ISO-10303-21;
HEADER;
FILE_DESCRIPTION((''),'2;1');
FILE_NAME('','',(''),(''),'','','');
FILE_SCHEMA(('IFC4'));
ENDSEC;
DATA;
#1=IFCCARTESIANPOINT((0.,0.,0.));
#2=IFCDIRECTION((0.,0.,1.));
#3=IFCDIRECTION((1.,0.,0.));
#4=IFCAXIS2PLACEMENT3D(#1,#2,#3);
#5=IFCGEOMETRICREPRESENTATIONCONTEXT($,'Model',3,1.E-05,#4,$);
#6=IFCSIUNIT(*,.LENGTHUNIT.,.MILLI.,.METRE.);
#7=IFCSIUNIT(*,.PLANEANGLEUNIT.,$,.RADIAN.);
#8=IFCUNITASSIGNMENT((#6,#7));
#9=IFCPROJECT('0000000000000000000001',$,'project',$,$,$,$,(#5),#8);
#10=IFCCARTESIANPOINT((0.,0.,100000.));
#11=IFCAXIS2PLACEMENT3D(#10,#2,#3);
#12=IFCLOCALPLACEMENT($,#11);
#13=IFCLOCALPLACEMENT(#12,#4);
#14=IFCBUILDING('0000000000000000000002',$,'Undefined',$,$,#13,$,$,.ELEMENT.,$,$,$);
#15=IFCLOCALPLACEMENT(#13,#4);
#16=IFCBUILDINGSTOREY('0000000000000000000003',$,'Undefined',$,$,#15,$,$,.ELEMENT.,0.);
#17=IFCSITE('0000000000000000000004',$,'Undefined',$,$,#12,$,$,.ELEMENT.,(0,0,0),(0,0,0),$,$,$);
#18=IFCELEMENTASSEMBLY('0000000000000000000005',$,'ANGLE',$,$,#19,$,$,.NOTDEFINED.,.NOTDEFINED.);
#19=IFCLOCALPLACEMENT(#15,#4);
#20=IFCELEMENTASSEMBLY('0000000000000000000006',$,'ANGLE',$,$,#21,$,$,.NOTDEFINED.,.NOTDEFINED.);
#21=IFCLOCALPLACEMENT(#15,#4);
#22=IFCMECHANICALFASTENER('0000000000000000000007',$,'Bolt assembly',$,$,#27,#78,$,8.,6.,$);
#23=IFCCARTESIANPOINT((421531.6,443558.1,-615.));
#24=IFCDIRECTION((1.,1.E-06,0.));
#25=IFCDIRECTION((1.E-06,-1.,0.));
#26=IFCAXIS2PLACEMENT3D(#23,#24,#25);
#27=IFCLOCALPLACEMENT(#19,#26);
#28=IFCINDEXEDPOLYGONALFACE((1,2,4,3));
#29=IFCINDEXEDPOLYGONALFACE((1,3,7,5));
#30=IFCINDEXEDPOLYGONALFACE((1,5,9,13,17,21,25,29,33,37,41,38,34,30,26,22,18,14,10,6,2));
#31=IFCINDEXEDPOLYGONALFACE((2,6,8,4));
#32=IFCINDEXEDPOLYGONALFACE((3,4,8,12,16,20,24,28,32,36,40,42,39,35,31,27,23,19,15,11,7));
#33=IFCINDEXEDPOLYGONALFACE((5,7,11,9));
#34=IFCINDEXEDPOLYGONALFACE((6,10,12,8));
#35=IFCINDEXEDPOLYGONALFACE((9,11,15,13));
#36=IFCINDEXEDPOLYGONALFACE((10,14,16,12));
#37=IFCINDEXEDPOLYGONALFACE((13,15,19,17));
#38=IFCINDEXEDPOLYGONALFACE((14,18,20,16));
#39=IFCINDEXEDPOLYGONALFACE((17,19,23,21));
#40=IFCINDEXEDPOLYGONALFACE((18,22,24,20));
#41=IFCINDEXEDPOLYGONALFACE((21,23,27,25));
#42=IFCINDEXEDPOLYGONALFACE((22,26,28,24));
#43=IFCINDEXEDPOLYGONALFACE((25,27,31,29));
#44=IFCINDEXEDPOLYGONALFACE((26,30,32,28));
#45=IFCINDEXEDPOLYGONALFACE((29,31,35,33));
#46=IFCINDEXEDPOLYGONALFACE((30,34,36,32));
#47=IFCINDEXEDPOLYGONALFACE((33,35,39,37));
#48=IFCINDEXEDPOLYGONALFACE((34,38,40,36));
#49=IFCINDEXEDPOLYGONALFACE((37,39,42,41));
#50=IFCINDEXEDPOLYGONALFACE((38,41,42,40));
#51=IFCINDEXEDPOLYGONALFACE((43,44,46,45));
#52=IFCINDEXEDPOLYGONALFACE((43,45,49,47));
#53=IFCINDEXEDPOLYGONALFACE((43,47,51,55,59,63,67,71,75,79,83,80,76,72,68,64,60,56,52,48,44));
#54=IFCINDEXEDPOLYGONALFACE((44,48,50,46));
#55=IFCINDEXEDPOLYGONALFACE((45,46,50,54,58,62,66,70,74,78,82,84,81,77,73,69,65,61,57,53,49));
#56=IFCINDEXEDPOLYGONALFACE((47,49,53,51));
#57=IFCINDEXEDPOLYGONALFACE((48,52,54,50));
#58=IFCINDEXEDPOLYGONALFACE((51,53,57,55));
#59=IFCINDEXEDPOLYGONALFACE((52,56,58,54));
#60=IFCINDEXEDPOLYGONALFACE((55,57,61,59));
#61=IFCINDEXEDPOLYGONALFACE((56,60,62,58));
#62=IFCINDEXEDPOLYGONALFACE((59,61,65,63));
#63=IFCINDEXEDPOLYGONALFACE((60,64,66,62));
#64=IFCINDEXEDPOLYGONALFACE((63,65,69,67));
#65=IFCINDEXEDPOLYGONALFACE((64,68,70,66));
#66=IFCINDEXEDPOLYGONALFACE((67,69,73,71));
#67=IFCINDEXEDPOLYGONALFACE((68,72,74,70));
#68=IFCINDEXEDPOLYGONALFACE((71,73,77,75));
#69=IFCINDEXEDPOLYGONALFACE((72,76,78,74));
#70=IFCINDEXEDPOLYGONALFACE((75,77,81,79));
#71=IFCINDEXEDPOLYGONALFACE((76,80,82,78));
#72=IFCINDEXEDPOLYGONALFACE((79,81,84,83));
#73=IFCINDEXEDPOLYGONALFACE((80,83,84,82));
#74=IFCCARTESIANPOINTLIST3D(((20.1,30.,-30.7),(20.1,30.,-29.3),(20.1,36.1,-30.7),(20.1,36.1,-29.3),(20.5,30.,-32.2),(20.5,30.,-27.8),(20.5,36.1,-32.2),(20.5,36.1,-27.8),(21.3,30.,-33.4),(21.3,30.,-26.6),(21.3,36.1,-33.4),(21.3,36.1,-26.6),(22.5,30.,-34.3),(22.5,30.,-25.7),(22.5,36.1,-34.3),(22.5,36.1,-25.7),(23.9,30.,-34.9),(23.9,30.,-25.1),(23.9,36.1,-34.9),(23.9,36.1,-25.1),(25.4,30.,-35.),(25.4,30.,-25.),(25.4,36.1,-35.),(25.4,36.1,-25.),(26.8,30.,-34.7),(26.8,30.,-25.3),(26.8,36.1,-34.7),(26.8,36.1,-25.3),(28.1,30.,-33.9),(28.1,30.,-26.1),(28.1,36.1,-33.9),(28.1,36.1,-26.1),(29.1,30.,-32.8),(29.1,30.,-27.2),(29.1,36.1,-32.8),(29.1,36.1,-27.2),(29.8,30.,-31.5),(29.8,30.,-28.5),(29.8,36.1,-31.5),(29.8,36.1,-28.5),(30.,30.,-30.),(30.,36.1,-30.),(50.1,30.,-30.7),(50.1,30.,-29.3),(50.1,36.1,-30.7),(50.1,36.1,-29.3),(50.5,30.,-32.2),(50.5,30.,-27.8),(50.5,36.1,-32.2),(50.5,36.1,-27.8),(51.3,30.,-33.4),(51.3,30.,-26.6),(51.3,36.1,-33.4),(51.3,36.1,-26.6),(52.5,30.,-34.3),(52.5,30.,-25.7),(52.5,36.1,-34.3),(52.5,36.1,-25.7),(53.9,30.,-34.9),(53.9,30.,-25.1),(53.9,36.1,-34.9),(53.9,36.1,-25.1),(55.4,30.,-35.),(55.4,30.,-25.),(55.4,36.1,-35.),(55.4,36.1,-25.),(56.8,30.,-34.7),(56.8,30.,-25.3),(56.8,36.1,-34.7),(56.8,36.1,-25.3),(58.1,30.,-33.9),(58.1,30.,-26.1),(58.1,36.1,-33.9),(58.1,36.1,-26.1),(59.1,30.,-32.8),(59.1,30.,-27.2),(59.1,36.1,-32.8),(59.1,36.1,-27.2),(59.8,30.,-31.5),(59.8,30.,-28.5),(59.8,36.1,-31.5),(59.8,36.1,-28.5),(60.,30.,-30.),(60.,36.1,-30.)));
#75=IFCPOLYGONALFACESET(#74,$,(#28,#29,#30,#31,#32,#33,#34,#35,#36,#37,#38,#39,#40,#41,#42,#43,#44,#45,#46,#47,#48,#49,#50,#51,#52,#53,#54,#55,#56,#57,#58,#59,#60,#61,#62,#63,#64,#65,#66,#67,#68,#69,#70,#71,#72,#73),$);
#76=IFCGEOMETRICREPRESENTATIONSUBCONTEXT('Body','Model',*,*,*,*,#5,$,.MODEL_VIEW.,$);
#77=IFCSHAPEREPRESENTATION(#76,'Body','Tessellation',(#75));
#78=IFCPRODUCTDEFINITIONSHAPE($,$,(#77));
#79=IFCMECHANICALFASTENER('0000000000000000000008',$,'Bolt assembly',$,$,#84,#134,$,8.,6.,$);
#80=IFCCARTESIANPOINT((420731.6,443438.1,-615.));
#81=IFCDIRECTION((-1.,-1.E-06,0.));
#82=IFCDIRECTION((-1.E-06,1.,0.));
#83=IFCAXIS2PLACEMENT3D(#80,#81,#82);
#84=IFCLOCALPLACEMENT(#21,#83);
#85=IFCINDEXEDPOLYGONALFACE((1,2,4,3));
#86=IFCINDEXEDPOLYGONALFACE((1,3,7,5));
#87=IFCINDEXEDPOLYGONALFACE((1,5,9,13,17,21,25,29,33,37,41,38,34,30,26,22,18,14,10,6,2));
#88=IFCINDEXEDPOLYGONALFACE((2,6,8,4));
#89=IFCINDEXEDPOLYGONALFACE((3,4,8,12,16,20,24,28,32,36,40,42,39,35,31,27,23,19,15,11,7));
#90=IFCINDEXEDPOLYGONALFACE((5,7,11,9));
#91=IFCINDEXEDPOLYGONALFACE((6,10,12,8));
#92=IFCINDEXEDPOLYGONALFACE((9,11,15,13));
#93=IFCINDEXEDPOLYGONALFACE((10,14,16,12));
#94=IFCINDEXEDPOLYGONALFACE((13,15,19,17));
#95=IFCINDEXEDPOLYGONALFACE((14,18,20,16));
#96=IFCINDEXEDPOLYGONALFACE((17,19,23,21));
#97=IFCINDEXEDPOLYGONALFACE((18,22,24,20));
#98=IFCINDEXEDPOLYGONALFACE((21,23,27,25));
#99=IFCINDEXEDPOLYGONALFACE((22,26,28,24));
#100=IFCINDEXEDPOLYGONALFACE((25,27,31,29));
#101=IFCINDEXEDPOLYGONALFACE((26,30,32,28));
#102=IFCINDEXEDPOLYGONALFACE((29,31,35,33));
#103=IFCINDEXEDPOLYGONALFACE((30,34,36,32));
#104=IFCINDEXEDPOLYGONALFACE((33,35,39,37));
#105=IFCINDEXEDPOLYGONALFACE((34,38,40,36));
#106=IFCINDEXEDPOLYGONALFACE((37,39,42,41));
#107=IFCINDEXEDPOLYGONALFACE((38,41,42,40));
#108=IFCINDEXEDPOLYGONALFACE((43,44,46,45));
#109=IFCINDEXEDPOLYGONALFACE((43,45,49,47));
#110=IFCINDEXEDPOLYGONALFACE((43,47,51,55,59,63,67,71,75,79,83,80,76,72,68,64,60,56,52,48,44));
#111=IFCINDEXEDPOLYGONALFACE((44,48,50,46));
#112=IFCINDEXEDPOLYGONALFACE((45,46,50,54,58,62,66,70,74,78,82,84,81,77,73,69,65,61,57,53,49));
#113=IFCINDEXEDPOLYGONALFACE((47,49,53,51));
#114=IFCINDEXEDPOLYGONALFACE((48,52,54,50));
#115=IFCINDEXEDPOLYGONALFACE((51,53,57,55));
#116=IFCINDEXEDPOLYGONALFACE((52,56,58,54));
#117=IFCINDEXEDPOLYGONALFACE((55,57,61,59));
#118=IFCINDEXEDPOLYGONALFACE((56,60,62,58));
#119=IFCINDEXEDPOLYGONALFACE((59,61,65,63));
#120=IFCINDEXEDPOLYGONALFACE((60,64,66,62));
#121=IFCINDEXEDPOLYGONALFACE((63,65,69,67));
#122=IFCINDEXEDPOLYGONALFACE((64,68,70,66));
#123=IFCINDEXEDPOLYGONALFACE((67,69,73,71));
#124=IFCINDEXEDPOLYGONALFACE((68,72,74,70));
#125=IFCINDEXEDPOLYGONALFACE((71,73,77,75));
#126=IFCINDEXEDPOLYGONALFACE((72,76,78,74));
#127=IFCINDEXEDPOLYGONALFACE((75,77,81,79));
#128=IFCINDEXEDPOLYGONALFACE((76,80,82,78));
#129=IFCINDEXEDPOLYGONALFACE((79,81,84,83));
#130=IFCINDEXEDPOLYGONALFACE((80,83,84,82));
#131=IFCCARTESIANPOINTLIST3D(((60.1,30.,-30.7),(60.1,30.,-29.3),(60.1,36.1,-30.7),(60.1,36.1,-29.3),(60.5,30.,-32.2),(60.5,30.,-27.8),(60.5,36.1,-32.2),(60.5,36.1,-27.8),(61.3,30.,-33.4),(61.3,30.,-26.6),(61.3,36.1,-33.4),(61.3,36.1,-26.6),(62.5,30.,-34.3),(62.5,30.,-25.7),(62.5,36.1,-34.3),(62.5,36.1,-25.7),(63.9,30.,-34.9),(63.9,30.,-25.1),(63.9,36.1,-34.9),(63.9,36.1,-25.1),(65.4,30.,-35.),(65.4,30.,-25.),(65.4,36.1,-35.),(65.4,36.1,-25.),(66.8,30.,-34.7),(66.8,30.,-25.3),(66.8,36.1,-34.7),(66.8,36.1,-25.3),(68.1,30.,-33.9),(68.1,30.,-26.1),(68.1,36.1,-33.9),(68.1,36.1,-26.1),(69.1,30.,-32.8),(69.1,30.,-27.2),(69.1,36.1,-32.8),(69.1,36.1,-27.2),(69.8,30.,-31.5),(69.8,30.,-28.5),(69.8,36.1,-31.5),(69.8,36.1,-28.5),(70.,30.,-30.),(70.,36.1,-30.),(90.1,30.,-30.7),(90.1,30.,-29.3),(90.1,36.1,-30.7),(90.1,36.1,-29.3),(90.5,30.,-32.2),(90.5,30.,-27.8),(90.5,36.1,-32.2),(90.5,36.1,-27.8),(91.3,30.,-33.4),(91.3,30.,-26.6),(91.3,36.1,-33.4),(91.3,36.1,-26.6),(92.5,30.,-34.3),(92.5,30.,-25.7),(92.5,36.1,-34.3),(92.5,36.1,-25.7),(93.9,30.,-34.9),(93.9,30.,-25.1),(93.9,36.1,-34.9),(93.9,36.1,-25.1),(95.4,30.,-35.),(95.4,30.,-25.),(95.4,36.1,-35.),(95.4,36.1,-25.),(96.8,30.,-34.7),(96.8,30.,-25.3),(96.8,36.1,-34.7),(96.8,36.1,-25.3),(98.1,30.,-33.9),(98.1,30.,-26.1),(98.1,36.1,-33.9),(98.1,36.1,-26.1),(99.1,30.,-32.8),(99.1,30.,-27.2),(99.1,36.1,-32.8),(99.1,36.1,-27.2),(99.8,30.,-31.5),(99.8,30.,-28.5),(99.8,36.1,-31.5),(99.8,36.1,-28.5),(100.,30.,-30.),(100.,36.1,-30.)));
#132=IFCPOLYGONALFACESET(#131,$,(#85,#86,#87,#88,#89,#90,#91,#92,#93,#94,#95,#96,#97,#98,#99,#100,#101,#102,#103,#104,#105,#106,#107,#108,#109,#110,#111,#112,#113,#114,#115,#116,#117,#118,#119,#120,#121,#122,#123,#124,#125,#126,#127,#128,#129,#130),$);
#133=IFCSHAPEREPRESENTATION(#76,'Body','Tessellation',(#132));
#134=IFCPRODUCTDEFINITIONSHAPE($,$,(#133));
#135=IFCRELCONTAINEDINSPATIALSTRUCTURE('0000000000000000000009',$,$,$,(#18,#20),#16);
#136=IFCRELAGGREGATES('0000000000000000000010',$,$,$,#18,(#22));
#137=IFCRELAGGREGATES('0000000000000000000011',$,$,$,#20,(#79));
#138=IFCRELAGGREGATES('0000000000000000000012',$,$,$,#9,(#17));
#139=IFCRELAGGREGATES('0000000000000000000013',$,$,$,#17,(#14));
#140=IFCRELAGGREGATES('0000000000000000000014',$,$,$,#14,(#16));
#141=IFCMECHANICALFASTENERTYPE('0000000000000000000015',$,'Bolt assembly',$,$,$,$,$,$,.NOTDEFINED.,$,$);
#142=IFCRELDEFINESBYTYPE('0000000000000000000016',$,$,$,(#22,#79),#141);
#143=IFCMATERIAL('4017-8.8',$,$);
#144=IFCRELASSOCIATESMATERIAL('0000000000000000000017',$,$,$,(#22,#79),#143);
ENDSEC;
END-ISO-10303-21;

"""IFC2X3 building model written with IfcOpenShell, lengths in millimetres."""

from ifc_helpers import new_model, si_unit, frame, origin_with_axes, origin_2d_with_axis, place, context, subcontext, project, spatial, circle, extrude, source, transform, mapped, material, type_object, element, aggregate, save


model = new_model("IFC2X3")

# Units and contexts
model_context = context("Model", 3, precision=1e-05, world=origin_with_axes())
body_context = subcontext(model_context, "Body", "Model", "MODEL_VIEW")
ifc_project = project(units=[si_unit("LENGTHUNIT", "METRE", prefix="MILLI"), si_unit("PLANEANGLEUNIT", "RADIAN")], contexts=[model_context])

# Site, building, storey
site_placement = place(None, frame((0.0, 0.0, 100000.0), z_axis=(0.0, 0.0, 1.0), x_axis=(1.0, 0.0, 0.0)))
site = spatial("IfcSite", under=ifc_project, at=site_placement, Name="Undefined", CompositionType="ELEMENT", RefLatitude=(0, 0, 0), RefLongitude=(0, 0, 0))
building_placement = place(site_placement, origin_with_axes())
building = spatial("IfcBuilding", under=site, at=building_placement, Name="Undefined", CompositionType="ELEMENT")
storey_placement = place(building_placement, origin_with_axes())
storey = spatial("IfcBuildingStorey", under=building, at=storey_placement, Name="Undefined", CompositionType="ELEMENT", Elevation=0.0)

# Element assemblies
assembly_1_placement = place(storey_placement, origin_with_axes())
assembly_1 = element("IfcElementAssembly", 1, at=assembly_1_placement, inside=storey, Name="ANGLE", AssemblyPlace="NOTDEFINED", PredefinedType="NOTDEFINED")
assembly_2_placement = place(storey_placement, origin_with_axes())
assembly_2 = element("IfcElementAssembly", 2, at=assembly_2_placement, inside=storey, Name="ANGLE", AssemblyPlace="NOTDEFINED", PredefinedType="NOTDEFINED")

# Mechanical fasteners
ifc_material_1 = material(Name="4017-8.8")
mechanical_fastener_type = type_object("IfcMechanicalFastenerType", Name="Bolt assembly")
shared_shape_1 = source(origin_with_axes(), body_context, "Body", "SweptSolid", [
    extrude(circle(Radius=5.0, at=origin_2d_with_axis()), frame((0.0, 30.0, 0.0), z_axis=(0.0, 1.0, 0.0), x_axis=(1.0, 0.0, 0.0)), (0.0, 0.0, 1.0), 6.1),
])
mechanical_fastener_1_placement = place(assembly_1_placement, frame((421531.6, 443558.1, -615.0), z_axis=(1.0, 0.000001, 0.0), x_axis=(0.000001, -1.0, 0.0)))
mechanical_fastener_1 = element("IfcMechanicalFastener", 3, at=mechanical_fastener_1_placement, type_object=mechanical_fastener_type, material=ifc_material_1, Name="Bolt assembly", NominalDiameter=8.0, NominalLength=6.0, context=body_context, shape_type="MappedRepresentation", body=[
    mapped(shared_shape_1, transform((25.0, 0.0, -30.0))),
    mapped(shared_shape_1, transform((55.0, 0.0, -30.0))),
])
aggregate(assembly_1, [mechanical_fastener_1])
mechanical_fastener_2_placement = place(assembly_2_placement, frame((420731.6, 443438.1, -615.0), z_axis=(-1.0, -0.000001, 0.0), x_axis=(-0.000001, 1.0, 0.0)))
mechanical_fastener_2 = element("IfcMechanicalFastener", 4, at=mechanical_fastener_2_placement, type_object=mechanical_fastener_type, material=ifc_material_1, Name="Bolt assembly", NominalDiameter=8.0, NominalLength=6.0, context=body_context, shape_type="MappedRepresentation", body=[
    mapped(shared_shape_1, transform((95.0, 0.0, -30.0))),
    mapped(shared_shape_1, transform((65.0, 0.0, -30.0))),
])
aggregate(assembly_2, [mechanical_fastener_2])

save(model, "model.ifc")
